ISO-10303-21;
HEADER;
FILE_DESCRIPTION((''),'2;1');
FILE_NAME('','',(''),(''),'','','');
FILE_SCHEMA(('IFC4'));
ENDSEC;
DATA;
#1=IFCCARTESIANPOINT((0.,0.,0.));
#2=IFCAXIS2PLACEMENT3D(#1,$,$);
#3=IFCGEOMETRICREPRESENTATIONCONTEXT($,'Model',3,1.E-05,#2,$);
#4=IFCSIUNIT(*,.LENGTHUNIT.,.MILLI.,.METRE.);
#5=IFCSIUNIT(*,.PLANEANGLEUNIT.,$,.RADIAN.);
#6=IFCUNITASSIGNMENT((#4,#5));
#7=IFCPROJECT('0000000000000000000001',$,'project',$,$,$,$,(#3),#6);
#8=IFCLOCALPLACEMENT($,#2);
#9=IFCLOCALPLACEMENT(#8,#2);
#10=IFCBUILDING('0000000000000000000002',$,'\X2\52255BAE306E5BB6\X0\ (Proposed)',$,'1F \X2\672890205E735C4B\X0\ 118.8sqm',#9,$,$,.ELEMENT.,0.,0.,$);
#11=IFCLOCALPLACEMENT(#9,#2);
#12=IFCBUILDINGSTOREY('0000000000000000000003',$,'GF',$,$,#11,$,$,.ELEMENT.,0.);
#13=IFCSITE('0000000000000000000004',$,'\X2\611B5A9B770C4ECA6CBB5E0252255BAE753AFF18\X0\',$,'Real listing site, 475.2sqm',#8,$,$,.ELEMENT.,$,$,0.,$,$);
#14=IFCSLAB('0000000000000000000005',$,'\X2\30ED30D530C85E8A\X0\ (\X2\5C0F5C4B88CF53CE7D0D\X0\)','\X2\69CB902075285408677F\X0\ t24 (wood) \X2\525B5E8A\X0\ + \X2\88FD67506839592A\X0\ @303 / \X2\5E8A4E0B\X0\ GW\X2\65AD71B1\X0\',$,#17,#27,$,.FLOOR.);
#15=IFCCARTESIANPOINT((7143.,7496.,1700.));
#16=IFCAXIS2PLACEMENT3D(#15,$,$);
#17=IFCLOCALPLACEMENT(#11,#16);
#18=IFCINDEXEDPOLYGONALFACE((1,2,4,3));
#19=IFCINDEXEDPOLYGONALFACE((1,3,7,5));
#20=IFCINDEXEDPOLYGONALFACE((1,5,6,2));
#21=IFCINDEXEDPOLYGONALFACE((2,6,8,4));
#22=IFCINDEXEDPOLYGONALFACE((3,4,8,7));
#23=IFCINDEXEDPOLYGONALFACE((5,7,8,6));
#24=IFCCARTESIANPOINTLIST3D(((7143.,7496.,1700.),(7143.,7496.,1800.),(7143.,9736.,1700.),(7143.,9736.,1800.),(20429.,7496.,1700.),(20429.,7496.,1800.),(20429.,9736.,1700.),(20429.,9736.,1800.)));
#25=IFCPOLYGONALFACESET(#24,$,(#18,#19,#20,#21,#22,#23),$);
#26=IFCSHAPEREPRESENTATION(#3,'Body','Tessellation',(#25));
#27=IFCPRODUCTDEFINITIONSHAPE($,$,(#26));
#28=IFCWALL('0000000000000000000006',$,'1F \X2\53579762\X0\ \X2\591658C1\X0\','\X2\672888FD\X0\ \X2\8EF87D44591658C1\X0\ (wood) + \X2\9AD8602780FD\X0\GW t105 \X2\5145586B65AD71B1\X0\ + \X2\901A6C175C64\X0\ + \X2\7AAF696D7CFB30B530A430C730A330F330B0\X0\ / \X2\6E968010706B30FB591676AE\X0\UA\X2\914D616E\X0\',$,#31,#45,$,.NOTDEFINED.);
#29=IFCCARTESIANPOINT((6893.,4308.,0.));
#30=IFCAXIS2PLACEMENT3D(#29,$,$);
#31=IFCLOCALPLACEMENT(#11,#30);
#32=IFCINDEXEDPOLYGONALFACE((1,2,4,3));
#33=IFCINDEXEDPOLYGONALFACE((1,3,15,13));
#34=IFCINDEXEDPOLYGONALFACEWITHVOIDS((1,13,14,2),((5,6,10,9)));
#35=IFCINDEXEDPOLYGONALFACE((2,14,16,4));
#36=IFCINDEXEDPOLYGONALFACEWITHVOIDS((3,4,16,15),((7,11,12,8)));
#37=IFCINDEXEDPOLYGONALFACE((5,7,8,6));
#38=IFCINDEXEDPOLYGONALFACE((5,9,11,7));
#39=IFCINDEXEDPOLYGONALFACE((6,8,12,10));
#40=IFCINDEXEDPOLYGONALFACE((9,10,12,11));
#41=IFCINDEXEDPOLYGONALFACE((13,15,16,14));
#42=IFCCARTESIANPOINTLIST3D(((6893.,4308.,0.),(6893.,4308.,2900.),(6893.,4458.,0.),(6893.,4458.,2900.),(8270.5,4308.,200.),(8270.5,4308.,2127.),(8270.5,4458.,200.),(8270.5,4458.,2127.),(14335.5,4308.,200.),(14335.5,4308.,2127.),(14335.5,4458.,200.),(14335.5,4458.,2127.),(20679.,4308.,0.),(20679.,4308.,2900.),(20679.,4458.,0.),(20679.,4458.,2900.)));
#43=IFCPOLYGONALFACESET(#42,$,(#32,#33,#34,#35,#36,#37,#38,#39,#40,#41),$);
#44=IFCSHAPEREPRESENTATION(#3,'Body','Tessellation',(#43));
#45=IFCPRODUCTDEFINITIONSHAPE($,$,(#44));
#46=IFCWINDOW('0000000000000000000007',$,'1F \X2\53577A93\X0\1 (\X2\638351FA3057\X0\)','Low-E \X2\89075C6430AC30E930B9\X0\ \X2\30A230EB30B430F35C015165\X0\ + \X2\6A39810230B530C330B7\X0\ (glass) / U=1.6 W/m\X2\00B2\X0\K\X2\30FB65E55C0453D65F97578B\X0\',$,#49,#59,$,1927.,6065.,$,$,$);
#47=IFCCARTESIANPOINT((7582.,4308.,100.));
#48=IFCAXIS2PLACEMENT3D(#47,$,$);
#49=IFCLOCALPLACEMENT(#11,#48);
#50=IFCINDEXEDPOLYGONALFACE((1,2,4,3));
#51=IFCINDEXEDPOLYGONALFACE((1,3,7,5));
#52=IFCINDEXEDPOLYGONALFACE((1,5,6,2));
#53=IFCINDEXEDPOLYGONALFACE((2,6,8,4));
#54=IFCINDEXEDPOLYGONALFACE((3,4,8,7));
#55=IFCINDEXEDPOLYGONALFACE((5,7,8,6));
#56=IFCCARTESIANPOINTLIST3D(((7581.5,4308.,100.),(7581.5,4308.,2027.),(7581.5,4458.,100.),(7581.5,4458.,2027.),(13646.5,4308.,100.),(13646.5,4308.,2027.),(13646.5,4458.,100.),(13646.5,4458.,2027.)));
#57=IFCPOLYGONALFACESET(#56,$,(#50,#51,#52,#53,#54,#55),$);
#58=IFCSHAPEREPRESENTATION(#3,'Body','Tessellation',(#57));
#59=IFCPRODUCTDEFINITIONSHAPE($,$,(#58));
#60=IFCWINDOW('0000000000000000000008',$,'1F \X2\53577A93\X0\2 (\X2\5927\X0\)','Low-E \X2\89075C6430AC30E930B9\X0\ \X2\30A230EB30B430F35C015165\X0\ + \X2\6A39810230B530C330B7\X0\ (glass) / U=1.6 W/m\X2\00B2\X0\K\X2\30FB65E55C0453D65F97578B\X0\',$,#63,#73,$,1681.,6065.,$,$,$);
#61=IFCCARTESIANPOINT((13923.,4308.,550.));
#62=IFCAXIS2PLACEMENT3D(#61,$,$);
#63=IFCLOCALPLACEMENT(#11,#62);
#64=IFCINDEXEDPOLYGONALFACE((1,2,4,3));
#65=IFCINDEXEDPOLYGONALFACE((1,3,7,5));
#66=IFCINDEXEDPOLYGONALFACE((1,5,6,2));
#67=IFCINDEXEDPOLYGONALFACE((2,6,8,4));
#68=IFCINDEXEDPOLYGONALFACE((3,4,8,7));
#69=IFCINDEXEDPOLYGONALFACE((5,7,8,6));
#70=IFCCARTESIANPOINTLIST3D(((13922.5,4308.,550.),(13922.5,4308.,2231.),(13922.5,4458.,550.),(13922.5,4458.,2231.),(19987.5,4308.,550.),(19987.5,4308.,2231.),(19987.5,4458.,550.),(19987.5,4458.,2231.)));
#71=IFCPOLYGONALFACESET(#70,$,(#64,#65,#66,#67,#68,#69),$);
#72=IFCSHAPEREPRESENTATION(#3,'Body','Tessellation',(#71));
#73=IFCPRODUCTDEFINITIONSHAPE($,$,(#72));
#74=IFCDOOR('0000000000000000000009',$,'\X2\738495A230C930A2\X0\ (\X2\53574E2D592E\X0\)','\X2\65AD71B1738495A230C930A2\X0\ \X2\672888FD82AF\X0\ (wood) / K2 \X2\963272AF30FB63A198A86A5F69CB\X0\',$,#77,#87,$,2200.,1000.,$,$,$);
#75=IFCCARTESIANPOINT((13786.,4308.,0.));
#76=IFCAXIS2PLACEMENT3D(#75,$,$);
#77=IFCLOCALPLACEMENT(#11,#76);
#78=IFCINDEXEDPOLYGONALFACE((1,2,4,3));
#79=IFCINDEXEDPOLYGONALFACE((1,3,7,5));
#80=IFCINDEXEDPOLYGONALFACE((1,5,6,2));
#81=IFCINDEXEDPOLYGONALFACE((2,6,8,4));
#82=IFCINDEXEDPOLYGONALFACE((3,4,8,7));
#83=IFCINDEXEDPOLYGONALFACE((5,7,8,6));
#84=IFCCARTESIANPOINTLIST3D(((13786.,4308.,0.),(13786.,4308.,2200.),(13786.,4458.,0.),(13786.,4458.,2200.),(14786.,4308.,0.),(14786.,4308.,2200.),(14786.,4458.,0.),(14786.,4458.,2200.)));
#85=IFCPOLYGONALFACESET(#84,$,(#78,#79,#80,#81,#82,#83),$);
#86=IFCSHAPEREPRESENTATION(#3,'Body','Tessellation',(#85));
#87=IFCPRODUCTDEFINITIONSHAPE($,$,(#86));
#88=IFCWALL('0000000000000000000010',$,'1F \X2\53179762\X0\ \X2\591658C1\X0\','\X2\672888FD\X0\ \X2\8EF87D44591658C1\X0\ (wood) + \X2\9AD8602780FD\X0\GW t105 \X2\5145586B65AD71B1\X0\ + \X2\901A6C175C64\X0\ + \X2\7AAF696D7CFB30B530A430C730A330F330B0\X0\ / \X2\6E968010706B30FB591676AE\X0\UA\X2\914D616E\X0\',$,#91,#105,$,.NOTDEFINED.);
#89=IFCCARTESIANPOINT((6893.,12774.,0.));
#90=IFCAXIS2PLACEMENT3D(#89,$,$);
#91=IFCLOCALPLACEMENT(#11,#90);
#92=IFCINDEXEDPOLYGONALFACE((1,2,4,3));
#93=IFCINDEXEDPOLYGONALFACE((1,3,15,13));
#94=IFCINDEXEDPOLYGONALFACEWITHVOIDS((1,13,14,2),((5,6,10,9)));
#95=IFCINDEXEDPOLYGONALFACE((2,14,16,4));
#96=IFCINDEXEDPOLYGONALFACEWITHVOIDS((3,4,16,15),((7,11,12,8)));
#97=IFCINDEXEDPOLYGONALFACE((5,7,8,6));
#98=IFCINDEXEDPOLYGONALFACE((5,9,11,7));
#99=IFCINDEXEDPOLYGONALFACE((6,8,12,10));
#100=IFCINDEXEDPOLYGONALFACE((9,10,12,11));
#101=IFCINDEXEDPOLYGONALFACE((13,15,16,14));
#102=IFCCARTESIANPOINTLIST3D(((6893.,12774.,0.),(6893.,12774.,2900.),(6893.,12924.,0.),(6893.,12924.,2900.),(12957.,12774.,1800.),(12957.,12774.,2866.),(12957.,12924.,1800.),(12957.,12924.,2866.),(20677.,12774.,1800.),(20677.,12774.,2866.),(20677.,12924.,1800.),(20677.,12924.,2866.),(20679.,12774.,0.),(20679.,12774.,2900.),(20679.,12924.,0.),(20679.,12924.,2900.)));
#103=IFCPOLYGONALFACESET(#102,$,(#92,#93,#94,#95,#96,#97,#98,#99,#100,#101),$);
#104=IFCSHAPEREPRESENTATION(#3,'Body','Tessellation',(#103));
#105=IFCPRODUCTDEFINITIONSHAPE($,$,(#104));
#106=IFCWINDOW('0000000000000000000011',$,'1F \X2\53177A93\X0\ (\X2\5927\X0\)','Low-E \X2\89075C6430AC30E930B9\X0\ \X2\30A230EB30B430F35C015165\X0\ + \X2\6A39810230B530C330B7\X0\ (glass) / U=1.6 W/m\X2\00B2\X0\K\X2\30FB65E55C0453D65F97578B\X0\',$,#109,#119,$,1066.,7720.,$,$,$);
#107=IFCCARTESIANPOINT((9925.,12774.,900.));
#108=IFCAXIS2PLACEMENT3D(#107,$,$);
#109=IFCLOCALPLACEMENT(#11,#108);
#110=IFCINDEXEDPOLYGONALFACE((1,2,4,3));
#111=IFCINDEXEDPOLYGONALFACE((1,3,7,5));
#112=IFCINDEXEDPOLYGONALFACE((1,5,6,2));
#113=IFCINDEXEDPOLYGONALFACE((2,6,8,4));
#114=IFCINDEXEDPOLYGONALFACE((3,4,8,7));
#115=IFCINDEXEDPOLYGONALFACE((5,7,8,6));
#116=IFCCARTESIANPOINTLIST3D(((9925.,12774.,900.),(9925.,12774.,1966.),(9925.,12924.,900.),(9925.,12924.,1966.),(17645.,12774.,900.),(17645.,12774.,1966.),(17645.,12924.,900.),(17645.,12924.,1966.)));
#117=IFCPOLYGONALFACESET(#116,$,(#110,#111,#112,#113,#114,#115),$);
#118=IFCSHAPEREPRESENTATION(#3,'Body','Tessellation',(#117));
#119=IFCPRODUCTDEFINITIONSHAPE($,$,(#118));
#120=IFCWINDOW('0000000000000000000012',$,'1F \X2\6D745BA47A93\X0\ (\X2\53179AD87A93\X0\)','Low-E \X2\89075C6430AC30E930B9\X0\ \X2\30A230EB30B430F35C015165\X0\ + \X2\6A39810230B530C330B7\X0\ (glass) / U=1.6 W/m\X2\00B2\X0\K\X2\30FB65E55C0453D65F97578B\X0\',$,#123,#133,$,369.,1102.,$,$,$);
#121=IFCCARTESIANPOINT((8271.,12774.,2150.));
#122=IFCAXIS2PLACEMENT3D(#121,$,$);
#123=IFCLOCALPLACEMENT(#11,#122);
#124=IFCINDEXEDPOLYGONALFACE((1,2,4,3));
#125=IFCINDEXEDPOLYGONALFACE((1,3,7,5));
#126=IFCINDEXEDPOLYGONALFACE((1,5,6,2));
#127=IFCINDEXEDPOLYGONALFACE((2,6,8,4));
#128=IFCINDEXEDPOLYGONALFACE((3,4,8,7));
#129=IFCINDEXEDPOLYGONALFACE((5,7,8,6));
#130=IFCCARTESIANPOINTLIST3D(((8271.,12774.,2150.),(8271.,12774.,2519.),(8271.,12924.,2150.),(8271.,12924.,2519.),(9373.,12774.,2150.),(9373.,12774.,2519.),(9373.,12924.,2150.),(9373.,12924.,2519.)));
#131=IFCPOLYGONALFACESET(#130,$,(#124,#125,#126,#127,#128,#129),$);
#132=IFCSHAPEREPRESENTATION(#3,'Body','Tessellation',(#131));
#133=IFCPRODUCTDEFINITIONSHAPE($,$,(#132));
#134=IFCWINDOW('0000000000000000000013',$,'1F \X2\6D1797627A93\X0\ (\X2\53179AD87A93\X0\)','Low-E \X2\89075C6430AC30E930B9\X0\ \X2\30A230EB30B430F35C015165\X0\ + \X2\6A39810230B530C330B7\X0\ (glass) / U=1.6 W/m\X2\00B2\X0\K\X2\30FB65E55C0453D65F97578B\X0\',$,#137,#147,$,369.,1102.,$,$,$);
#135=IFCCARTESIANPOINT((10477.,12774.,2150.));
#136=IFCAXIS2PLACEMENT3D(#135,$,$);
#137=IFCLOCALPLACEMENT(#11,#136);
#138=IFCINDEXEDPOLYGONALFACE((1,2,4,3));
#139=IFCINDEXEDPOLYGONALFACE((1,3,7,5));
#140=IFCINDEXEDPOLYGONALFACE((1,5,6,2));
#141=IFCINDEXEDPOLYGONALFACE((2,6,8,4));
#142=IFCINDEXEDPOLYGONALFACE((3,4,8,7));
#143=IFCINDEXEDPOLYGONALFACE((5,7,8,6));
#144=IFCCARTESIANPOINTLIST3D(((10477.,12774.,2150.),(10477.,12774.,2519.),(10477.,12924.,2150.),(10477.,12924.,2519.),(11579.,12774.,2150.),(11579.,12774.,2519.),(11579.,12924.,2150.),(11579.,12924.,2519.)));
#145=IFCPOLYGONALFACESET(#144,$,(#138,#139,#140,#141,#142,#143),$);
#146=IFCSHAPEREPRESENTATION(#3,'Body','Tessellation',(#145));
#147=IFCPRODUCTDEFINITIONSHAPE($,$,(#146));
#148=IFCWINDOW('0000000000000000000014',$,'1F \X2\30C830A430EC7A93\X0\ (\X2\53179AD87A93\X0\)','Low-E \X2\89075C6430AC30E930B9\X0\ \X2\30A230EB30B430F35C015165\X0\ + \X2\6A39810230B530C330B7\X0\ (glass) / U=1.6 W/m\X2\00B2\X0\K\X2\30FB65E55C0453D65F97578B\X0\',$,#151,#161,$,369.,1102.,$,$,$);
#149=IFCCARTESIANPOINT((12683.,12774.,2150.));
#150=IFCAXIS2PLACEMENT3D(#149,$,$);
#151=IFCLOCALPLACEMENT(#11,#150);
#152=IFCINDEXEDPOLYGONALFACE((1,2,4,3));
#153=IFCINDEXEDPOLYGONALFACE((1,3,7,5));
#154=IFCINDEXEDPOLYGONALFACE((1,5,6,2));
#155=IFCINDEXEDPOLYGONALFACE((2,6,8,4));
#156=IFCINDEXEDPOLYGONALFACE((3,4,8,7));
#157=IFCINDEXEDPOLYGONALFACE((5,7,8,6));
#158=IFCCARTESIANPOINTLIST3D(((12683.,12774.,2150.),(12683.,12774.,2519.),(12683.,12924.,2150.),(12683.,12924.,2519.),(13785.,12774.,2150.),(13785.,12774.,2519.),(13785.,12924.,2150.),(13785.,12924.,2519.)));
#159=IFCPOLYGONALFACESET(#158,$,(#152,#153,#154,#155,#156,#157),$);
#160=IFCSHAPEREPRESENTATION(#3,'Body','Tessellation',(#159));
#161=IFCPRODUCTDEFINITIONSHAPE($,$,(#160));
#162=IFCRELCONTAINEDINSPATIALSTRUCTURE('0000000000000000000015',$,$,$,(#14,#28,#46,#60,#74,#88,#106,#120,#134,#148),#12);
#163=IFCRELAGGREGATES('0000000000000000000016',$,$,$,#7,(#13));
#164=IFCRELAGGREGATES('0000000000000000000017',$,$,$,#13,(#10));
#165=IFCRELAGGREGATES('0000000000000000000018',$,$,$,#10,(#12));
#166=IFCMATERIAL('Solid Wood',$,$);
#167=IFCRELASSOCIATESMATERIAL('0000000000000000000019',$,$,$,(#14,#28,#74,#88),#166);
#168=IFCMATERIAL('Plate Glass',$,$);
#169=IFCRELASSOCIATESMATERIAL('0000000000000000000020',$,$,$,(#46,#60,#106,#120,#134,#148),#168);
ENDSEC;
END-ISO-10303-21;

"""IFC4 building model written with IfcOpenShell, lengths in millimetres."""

from ifc_helpers import new_model, si_unit, frame, frame_2d, origin, place, context, project, spatial, rectangle, extrude, material, element, fill, save


model = new_model("IFC4")

# Units and contexts
model_context = context("Model", 3, precision=1e-05, world=origin())
ifc_project = project(units=[si_unit("LENGTHUNIT", "METRE", prefix="MILLI"), si_unit("PLANEANGLEUNIT", "RADIAN")], contexts=[model_context])

# Site, building, storey
site_placement = place(None, origin())
site = spatial("IfcSite", under=ifc_project, at=site_placement, Name="愛媛県今治市別宮町８", ObjectType="Real listing site, 475.2sqm", CompositionType="ELEMENT", RefElevation=0.0)
building_placement = place(site_placement, origin())
building = spatial("IfcBuilding", under=site, at=building_placement, Name="別宮の家 (Proposed)", ObjectType="1F 木造平屋 118.8sqm", CompositionType="ELEMENT", ElevationOfRefHeight=0.0, ElevationOfTerrain=0.0)
storey_placement = place(building_placement, origin())
storey = spatial("IfcBuildingStorey", under=building, at=storey_placement, Name="GF", CompositionType="ELEMENT", Elevation=0.0)

# Slab
ifc_material_1 = material(Name="Solid Wood")
slab_1_placement = place(storey_placement, frame((7143.0, 7496.0, 1700.0)))
element("IfcSlab", 1, at=slab_1_placement, inside=storey, material=ifc_material_1, Name="ロフト床 (小屋裏収納)", Description="構造用合板 t24 (wood) 剛床 + 製材根太 @303 / 床下 GW断熱", PredefinedType="FLOOR", context=model_context, shape_type="SweptSolid", body=[
    extrude(rectangle(XDim=13286.0, YDim=2240.0, at=frame_2d((6643.0, 1120.0))), frame((7143.0, 7496.0, 1700.0)), (0.0, 0.0, 1.0), 100.0),
])

# Wall, openings, windows, door
wall_1_placement = place(storey_placement, frame((6893.0, 4308.0, 0.0)))
wall_1 = element("IfcWall", 2, at=wall_1_placement, inside=storey, material=ifc_material_1, Name="1F 南面 外壁", Description="木製 軸組外壁 (wood) + 高性能GW t105 充填断熱 + 通気層 + 窯業系サイディング / 準耐火・外皮UA配慮", PredefinedType="NOTDEFINED", context=model_context, shape_type="SweptSolid", body=[
    extrude(rectangle(XDim=13786.0, YDim=150.0, at=frame_2d((6893.0, 75.0))), frame((6893.0, 4308.0, 0.0)), (0.0, 0.0, 1.0), 2900.0),
])
opening_1_placement = place(storey_placement, frame((7582.0, 4308.0, 100.0)))
opening_1 = element("IfcOpeningElement", 3, at=opening_1_placement, cuts=wall_1, PredefinedType="NOTDEFINED", context=model_context, shape_type="SweptSolid", body=[
    extrude(rectangle(XDim=6065.0, YDim=150.0, at=frame_2d((3032.0, 75.0))), frame((7582.0, 4308.0, 100.0)), (0.0, 0.0, 1.0), 1927.0),
])
opening_2_placement = place(storey_placement, frame((13923.0, 4308.0, 550.0)))
opening_2 = element("IfcOpeningElement", 4, at=opening_2_placement, cuts=wall_1, PredefinedType="NOTDEFINED", context=model_context, shape_type="SweptSolid", body=[
    extrude(rectangle(XDim=6065.0, YDim=150.0, at=frame_2d((3032.0, 75.0))), frame((13923.0, 4308.0, 550.0)), (0.0, 0.0, 1.0), 1681.0),
])
opening_3_placement = place(storey_placement, frame((13786.0, 4308.0, 0.0)))
opening_3 = element("IfcOpeningElement", 5, at=opening_3_placement, cuts=wall_1, PredefinedType="NOTDEFINED", context=model_context, shape_type="SweptSolid", body=[
    extrude(rectangle(XDim=1000.0, YDim=150.0, at=frame_2d((500.0, 75.0))), frame((13786.0, 4308.0, 0.0)), (0.0, 0.0, 1.0), 2200.0),
])
ifc_material_2 = material(Name="Plate Glass")
window_1_placement = place(storey_placement, frame((7582.0, 4308.0, 100.0)))
window_1 = element("IfcWindow", 6, at=window_1_placement, inside=storey, material=ifc_material_2, Name="1F 南窓1 (掃出し)", Description="Low-E 複層ガラス アルゴン封入 + 樹脂サッシ (glass) / U=1.6 W/m²K・日射取得型", OverallHeight=1927.0, OverallWidth=6065.0, context=model_context, shape_type="SweptSolid", body=[
    extrude(rectangle(XDim=6065.0, YDim=150.0, at=frame_2d((3032.0, 75.0))), frame((7582.0, 4308.0, 100.0)), (0.0, 0.0, 1.0), 1927.0),
])
fill(opening_1, window_1)
window_2_placement = place(storey_placement, frame((13923.0, 4308.0, 550.0)))
window_2 = element("IfcWindow", 7, at=window_2_placement, inside=storey, material=ifc_material_2, Name="1F 南窓2 (大)", Description="Low-E 複層ガラス アルゴン封入 + 樹脂サッシ (glass) / U=1.6 W/m²K・日射取得型", OverallHeight=1681.0, OverallWidth=6065.0, context=model_context, shape_type="SweptSolid", body=[
    extrude(rectangle(XDim=6065.0, YDim=150.0, at=frame_2d((3032.0, 75.0))), frame((13923.0, 4308.0, 550.0)), (0.0, 0.0, 1.0), 1681.0),
])
fill(opening_2, window_2)
door_1_placement = place(storey_placement, frame((13786.0, 4308.0, 0.0)))
door_1 = element("IfcDoor", 8, at=door_1_placement, inside=storey, material=ifc_material_1, Name="玄関ドア (南中央)", Description="断熱玄関ドア 木製芯 (wood) / K2 防犯・採風機構", OverallHeight=2200.0, OverallWidth=1000.0, context=model_context, shape_type="SweptSolid", body=[
    extrude(rectangle(XDim=1000.0, YDim=150.0, at=frame_2d((500.0, 75.0))), frame((13786.0, 4308.0, 0.0)), (0.0, 0.0, 1.0), 2200.0),
])
fill(opening_3, door_1)

# Wall, openings, windows
wall_2_placement = place(storey_placement, frame((6893.0, 12774.0, 0.0)))
wall_2 = element("IfcWall", 9, at=wall_2_placement, inside=storey, material=ifc_material_1, Name="1F 北面 外壁", Description="木製 軸組外壁 (wood) + 高性能GW t105 充填断熱 + 通気層 + 窯業系サイディング / 準耐火・外皮UA配慮", PredefinedType="NOTDEFINED", context=model_context, shape_type="SweptSolid", body=[
    extrude(rectangle(XDim=13786.0, YDim=150.0, at=frame_2d((6893.0, 75.0))), frame((6893.0, 12774.0, 0.0)), (0.0, 0.0, 1.0), 2900.0),
])
opening_4_placement = place(storey_placement, frame((9925.0, 12774.0, 900.0)))
opening_4 = element("IfcOpeningElement", 10, at=opening_4_placement, cuts=wall_2, PredefinedType="NOTDEFINED", context=model_context, shape_type="SweptSolid", body=[
    extrude(rectangle(XDim=7720.0, YDim=150.0, at=frame_2d((3860.0, 75.0))), frame((9925.0, 12774.0, 900.0)), (0.0, 0.0, 1.0), 1066.0),
])
opening_5_placement = place(storey_placement, frame((8271.0, 12774.0, 2150.0)))
opening_5 = element("IfcOpeningElement", 11, at=opening_5_placement, cuts=wall_2, PredefinedType="NOTDEFINED", context=model_context, shape_type="SweptSolid", body=[
    extrude(rectangle(XDim=1102.0, YDim=150.0, at=frame_2d((551.0, 75.0))), frame((8271.0, 12774.0, 2150.0)), (0.0, 0.0, 1.0), 369.0),
])
opening_6_placement = place(storey_placement, frame((10477.0, 12774.0, 2150.0)))
opening_6 = element("IfcOpeningElement", 12, at=opening_6_placement, cuts=wall_2, PredefinedType="NOTDEFINED", context=model_context, shape_type="SweptSolid", body=[
    extrude(rectangle(XDim=1102.0, YDim=150.0, at=frame_2d((551.0, 75.0))), frame((10477.0, 12774.0, 2150.0)), (0.0, 0.0, 1.0), 369.0),
])
opening_7_placement = place(storey_placement, frame((12683.0, 12774.0, 2150.0)))
opening_7 = element("IfcOpeningElement", 13, at=opening_7_placement, cuts=wall_2, PredefinedType="NOTDEFINED", context=model_context, shape_type="SweptSolid", body=[
    extrude(rectangle(XDim=1102.0, YDim=150.0, at=frame_2d((551.0, 75.0))), frame((12683.0, 12774.0, 2150.0)), (0.0, 0.0, 1.0), 369.0),
])
window_3_placement = place(storey_placement, frame((9925.0, 12774.0, 900.0)))
window_3 = element("IfcWindow", 14, at=window_3_placement, inside=storey, material=ifc_material_2, Name="1F 北窓 (大)", Description="Low-E 複層ガラス アルゴン封入 + 樹脂サッシ (glass) / U=1.6 W/m²K・日射取得型", OverallHeight=1066.0, OverallWidth=7720.0, context=model_context, shape_type="SweptSolid", body=[
    extrude(rectangle(XDim=7720.0, YDim=150.0, at=frame_2d((3860.0, 75.0))), frame((9925.0, 12774.0, 900.0)), (0.0, 0.0, 1.0), 1066.0),
])
fill(opening_4, window_3)
window_4_placement = place(storey_placement, frame((8271.0, 12774.0, 2150.0)))
window_4 = element("IfcWindow", 15, at=window_4_placement, inside=storey, material=ifc_material_2, Name="1F 浴室窓 (北高窓)", Description="Low-E 複層ガラス アルゴン封入 + 樹脂サッシ (glass) / U=1.6 W/m²K・日射取得型", OverallHeight=369.0, OverallWidth=1102.0, context=model_context, shape_type="SweptSolid", body=[
    extrude(rectangle(XDim=1102.0, YDim=150.0, at=frame_2d((551.0, 75.0))), frame((8271.0, 12774.0, 2150.0)), (0.0, 0.0, 1.0), 369.0),
])
fill(opening_5, window_4)
window_5_placement = place(storey_placement, frame((10477.0, 12774.0, 2150.0)))
window_5 = element("IfcWindow", 16, at=window_5_placement, inside=storey, material=ifc_material_2, Name="1F 洗面窓 (北高窓)", Description="Low-E 複層ガラス アルゴン封入 + 樹脂サッシ (glass) / U=1.6 W/m²K・日射取得型", OverallHeight=369.0, OverallWidth=1102.0, context=model_context, shape_type="SweptSolid", body=[
    extrude(rectangle(XDim=1102.0, YDim=150.0, at=frame_2d((551.0, 75.0))), frame((10477.0, 12774.0, 2150.0)), (0.0, 0.0, 1.0), 369.0),
])
fill(opening_6, window_5)
window_6_placement = place(storey_placement, frame((12683.0, 12774.0, 2150.0)))
window_6 = element("IfcWindow", 17, at=window_6_placement, inside=storey, material=ifc_material_2, Name="1F トイレ窓 (北高窓)", Description="Low-E 複層ガラス アルゴン封入 + 樹脂サッシ (glass) / U=1.6 W/m²K・日射取得型", OverallHeight=369.0, OverallWidth=1102.0, context=model_context, shape_type="SweptSolid", body=[
    extrude(rectangle(XDim=1102.0, YDim=150.0, at=frame_2d((551.0, 75.0))), frame((12683.0, 12774.0, 2150.0)), (0.0, 0.0, 1.0), 369.0),
])
fill(opening_7, window_6)

save(model, "model.ifc")
